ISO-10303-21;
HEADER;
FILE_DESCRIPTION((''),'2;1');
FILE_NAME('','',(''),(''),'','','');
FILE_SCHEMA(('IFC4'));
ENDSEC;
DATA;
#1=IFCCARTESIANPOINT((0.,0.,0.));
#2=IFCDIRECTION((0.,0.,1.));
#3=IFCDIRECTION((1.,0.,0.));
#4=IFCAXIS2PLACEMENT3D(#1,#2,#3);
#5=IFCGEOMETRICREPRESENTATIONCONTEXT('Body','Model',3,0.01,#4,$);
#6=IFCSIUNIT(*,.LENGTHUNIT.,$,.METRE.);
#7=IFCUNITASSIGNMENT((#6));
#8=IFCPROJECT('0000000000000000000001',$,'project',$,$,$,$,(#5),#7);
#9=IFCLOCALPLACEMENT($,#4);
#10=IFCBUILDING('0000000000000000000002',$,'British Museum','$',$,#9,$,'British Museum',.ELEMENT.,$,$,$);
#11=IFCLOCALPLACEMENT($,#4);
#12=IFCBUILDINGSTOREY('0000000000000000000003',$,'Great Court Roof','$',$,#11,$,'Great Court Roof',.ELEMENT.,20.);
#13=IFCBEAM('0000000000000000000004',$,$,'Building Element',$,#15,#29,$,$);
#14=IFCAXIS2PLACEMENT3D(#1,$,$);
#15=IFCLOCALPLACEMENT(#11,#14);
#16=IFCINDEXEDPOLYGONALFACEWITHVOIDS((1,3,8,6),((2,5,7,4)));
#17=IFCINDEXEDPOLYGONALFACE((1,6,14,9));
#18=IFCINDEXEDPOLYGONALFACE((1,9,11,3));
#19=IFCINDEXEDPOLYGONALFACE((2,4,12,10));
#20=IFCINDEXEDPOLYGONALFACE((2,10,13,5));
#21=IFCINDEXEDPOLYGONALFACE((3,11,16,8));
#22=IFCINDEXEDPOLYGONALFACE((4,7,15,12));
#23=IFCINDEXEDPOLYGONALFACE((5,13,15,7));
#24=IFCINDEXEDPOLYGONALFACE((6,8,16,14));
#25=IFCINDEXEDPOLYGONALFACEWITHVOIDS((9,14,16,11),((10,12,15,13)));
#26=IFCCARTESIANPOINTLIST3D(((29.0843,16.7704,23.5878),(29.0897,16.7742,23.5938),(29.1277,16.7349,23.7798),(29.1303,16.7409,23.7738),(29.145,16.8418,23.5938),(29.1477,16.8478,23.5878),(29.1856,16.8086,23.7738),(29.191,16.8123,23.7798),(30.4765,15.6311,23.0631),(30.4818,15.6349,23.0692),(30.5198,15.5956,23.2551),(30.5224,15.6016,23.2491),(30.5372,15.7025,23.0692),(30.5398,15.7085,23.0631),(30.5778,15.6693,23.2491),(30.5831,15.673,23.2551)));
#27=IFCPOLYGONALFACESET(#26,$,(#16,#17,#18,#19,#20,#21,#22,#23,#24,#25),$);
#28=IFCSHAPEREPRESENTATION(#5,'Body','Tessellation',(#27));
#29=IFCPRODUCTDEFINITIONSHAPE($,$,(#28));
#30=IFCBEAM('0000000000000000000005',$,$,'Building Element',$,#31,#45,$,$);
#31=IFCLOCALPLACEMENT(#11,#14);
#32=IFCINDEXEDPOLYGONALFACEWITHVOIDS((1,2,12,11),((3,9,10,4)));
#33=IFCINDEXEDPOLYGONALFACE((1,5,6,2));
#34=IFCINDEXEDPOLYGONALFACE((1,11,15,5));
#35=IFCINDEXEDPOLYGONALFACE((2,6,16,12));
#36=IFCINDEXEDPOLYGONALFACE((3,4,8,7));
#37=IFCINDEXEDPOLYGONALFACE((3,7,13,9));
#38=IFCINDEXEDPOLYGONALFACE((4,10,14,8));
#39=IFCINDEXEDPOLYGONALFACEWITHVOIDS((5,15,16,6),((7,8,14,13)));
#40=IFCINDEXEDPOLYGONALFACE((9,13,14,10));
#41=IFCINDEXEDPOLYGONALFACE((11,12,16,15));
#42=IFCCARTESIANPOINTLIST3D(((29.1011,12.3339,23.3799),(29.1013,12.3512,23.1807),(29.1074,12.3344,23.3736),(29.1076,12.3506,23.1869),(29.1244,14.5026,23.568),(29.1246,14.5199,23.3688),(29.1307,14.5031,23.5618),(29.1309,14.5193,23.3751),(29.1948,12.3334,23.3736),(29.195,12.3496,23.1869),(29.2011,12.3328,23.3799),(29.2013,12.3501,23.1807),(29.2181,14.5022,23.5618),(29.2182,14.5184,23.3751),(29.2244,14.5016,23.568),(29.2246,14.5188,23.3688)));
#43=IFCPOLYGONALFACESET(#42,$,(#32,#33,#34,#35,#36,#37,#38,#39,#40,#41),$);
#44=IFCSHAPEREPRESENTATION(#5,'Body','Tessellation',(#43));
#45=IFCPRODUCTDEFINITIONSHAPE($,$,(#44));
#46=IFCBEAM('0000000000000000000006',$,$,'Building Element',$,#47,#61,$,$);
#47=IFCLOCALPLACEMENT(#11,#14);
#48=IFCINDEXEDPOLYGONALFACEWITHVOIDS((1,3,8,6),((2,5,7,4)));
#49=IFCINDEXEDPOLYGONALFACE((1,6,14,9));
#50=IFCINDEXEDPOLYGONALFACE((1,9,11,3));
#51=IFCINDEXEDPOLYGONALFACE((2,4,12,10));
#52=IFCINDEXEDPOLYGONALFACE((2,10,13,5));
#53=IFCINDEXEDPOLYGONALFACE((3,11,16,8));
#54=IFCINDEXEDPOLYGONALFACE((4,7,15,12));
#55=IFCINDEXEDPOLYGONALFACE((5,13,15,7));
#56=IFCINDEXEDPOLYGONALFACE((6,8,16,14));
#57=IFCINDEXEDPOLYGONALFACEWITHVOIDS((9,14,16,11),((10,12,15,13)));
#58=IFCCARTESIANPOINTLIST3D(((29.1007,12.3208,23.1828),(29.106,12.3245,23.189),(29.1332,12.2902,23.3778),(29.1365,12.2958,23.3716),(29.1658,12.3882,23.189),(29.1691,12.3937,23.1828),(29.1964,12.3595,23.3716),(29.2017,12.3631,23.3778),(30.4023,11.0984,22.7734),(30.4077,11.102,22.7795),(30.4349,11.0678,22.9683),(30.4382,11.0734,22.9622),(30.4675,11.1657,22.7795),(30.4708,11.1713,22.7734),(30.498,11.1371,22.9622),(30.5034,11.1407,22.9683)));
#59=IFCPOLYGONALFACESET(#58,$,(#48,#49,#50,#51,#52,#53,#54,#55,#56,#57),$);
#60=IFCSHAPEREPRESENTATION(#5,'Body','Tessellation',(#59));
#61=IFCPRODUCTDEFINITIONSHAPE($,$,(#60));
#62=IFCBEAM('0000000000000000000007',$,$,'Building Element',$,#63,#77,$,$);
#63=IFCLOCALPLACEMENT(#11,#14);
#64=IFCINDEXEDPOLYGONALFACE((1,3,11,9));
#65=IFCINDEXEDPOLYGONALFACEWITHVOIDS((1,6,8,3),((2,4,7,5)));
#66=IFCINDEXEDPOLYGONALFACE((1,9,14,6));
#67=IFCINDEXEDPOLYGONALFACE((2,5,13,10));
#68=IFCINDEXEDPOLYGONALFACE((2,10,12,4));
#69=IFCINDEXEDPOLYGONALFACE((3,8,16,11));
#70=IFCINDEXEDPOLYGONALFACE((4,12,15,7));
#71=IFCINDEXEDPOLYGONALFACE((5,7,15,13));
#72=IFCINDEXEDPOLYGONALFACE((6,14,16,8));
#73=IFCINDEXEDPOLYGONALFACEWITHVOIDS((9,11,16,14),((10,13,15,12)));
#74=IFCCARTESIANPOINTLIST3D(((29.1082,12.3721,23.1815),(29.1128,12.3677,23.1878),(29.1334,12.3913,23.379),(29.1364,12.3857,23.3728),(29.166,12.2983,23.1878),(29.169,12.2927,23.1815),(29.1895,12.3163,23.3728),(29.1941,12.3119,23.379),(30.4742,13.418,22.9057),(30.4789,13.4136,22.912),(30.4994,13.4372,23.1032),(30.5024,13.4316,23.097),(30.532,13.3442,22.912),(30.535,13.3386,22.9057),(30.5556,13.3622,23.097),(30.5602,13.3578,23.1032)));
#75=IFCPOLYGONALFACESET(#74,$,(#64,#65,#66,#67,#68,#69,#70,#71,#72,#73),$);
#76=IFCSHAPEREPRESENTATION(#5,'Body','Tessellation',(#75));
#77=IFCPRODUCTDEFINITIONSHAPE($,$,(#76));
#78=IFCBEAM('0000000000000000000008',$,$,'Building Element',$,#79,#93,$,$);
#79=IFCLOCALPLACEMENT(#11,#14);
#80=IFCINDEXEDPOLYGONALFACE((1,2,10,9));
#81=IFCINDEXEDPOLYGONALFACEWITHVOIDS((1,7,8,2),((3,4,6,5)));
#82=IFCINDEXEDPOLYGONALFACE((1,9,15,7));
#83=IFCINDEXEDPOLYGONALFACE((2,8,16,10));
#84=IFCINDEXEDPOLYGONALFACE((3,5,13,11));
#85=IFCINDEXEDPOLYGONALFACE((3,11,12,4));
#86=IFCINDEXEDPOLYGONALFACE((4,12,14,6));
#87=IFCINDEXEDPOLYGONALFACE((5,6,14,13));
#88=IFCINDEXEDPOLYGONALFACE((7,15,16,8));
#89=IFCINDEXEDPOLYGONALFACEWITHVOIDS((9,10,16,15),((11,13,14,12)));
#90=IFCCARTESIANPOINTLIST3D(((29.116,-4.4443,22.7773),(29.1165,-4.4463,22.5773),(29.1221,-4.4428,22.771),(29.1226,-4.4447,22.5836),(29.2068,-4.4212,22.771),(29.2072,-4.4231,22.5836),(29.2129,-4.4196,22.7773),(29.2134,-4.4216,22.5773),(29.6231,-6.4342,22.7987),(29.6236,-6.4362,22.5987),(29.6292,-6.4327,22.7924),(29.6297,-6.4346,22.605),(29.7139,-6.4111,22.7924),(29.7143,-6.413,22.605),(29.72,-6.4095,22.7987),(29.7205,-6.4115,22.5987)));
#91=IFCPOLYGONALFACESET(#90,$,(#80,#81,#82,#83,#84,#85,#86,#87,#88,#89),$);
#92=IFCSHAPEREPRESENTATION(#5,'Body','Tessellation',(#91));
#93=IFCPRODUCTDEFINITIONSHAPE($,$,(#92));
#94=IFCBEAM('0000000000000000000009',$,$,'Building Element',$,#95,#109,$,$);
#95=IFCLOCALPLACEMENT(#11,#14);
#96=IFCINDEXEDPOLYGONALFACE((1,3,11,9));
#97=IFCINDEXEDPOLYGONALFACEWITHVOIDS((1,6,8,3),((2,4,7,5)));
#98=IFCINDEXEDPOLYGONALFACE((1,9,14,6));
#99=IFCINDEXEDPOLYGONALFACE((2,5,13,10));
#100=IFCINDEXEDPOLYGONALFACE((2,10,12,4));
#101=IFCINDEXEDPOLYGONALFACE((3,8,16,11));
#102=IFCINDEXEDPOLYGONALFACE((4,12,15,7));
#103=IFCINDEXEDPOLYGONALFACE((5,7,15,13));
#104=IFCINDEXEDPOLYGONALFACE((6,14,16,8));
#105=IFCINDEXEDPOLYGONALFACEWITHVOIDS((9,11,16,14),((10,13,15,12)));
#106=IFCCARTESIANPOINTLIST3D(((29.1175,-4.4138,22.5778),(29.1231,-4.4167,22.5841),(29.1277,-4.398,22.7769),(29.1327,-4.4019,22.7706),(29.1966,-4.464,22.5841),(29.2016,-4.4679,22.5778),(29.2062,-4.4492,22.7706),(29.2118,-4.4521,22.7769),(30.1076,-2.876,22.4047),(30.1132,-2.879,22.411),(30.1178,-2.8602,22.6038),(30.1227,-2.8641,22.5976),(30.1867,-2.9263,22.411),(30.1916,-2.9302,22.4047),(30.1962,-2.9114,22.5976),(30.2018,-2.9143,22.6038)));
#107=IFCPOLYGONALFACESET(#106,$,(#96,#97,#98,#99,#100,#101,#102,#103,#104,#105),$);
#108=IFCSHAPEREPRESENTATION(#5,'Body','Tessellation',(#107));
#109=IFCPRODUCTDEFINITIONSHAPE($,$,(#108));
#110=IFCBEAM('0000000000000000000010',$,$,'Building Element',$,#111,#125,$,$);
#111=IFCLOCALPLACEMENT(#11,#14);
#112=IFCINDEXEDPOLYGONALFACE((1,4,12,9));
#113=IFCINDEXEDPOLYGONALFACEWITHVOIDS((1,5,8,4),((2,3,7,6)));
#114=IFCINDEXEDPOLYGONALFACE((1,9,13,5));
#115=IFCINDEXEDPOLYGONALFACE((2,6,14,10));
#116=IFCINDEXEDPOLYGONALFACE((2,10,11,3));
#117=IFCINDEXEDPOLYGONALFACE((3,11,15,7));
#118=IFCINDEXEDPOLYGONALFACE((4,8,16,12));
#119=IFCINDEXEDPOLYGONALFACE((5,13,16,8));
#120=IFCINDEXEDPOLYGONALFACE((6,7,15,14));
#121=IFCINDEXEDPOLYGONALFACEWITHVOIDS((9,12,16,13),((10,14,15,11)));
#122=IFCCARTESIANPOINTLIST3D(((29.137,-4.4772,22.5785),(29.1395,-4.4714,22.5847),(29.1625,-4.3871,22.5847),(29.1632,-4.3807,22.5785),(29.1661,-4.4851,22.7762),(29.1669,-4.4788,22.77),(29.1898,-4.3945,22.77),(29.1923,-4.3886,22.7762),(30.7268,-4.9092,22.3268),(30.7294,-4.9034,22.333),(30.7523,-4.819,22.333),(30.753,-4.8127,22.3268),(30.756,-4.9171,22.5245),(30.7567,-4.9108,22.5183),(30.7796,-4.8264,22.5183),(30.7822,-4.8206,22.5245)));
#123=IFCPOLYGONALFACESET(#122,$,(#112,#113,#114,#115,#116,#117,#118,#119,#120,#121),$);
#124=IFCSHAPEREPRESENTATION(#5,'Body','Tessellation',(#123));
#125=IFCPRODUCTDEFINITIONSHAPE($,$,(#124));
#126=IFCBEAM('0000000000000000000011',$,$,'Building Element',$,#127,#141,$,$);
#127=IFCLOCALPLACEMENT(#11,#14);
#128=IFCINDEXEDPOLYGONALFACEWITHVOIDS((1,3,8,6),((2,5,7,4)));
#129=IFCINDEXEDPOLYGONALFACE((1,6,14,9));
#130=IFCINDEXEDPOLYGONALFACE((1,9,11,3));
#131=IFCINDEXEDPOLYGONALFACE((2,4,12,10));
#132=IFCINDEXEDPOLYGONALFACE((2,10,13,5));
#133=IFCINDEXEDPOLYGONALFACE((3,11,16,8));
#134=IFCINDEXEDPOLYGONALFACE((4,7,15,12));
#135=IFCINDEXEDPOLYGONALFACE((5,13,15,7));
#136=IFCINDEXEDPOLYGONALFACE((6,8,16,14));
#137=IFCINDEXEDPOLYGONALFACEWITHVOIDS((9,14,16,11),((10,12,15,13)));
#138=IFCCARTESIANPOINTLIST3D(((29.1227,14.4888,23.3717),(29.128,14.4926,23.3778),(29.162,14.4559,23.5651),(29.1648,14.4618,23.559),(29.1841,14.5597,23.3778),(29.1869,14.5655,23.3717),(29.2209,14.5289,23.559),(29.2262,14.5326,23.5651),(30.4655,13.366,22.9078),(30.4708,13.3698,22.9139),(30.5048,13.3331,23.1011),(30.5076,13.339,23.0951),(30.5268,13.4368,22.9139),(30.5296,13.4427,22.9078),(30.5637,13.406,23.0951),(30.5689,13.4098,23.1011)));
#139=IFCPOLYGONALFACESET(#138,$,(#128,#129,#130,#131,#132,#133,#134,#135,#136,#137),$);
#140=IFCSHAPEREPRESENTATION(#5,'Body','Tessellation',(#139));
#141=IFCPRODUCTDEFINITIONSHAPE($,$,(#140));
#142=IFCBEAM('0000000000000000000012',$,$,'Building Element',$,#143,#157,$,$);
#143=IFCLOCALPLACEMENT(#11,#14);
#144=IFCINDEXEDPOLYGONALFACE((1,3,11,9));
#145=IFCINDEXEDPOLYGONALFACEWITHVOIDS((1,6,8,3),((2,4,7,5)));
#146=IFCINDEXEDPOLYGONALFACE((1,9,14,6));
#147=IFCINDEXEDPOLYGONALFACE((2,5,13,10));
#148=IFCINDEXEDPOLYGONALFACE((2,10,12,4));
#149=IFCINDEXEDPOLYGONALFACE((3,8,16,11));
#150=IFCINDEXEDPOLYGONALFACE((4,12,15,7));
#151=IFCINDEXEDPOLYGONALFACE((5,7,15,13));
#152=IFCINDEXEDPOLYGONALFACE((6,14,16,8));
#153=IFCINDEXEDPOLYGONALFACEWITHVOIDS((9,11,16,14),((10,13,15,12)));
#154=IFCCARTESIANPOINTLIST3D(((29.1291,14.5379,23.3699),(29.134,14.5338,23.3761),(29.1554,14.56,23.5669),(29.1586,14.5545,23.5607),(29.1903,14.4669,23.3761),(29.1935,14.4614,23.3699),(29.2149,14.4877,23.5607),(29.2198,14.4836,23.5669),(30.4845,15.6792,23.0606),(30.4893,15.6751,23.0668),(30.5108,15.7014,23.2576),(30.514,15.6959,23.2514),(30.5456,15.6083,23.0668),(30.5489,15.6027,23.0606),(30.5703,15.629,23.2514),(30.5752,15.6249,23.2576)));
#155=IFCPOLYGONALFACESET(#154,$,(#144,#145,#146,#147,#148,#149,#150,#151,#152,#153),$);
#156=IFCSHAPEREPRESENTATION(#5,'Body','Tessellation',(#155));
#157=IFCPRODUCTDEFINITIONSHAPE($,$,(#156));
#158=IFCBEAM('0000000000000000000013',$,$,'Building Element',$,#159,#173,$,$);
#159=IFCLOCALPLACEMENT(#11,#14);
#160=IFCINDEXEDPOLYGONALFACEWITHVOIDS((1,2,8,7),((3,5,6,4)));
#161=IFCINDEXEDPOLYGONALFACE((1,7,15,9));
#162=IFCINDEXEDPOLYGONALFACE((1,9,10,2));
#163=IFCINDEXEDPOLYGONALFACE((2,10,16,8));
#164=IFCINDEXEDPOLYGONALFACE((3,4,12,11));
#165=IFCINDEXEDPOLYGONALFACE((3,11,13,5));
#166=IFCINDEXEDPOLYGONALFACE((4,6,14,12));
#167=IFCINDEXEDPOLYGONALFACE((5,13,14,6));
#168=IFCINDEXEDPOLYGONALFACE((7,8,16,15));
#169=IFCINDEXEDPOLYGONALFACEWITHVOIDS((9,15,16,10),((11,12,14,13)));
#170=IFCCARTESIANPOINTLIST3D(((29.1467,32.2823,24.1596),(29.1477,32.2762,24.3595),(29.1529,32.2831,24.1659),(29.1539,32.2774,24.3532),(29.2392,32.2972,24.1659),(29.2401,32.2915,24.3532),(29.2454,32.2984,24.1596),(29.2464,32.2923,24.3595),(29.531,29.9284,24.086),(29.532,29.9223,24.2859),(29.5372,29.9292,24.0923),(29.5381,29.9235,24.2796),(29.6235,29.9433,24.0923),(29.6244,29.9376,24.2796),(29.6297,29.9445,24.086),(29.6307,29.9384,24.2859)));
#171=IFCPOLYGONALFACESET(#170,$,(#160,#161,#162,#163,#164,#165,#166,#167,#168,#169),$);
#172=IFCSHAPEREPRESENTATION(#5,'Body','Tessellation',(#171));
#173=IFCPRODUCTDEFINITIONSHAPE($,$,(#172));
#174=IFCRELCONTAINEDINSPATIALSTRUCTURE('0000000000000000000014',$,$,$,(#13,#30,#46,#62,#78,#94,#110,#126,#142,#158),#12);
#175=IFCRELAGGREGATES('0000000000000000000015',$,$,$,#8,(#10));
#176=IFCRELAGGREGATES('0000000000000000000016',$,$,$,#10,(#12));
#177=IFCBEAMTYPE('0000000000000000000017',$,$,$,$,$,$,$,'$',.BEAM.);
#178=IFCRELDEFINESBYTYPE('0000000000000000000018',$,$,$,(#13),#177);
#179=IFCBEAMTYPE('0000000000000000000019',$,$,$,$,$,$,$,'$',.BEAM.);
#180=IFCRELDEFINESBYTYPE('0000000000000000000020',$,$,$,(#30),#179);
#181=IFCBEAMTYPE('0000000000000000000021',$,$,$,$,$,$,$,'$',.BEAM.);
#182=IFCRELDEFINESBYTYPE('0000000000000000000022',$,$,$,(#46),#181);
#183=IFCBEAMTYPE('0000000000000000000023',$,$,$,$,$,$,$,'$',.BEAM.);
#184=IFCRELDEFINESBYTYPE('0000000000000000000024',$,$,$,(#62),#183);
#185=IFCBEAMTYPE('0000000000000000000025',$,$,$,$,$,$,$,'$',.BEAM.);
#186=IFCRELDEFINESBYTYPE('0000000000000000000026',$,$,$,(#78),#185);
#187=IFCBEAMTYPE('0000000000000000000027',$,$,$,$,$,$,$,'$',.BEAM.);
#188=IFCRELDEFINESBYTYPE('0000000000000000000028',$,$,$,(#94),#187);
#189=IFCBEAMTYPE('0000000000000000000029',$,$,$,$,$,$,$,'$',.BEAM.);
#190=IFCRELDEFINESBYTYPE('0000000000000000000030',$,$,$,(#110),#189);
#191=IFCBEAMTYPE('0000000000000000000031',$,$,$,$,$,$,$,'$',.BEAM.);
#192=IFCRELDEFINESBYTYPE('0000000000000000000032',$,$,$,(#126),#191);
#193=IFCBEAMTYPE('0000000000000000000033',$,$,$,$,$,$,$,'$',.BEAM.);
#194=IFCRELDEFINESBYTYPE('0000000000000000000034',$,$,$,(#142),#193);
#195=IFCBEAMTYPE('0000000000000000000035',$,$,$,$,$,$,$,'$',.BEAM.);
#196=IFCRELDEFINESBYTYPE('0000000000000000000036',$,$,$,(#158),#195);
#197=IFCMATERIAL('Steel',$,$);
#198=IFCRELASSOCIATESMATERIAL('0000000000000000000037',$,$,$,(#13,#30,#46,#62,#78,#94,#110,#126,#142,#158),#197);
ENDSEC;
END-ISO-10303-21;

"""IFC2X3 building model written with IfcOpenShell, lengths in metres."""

from ifc_helpers import new_model, si_unit, frame, origin_with_axes, origin_2d, place, context, project, spatial, hollow_rectangle, extrude, material, type_object, element, save


model = new_model("IFC2X3")

# Units and contexts
model_context = context("Model", 3, precision=0.01, world=origin_with_axes(), identifier="Body")
ifc_project = project(units=[si_unit("LENGTHUNIT", "METRE")], contexts=[model_context])

# Building, storey
building_placement = place(None, origin_with_axes())
building = spatial("IfcBuilding", under=ifc_project, at=building_placement, Name="British Museum", Description="$", LongName="British Museum", CompositionType="ELEMENT")
storey_placement = place(None, origin_with_axes())
storey = spatial("IfcBuildingStorey", under=building, at=storey_placement, Name="Great Court Roof", Description="$", LongName="Great Court Roof", CompositionType="ELEMENT", Elevation=20.0)

# Beams
ifc_material = material(Name="Steel")
beam_type_1 = type_object("IfcBeamType", ElementType="$", PredefinedType="BEAM")
beam_1_placement = place(None, origin_with_axes())
element("IfcBeam", 1, at=beam_1_placement, inside=storey, type_object=beam_type_1, material=ifc_material, Description="Building Element", context=model_context, shape_type="SweptSolid", body=[
    extrude(hollow_rectangle(XDim=0.1, YDim=0.2, WallThickness=0.0063, InnerFilletRadius=-0.0063, OuterFilletRadius=0.0, at=origin_2d()), frame((29.1377, 16.7914, 23.6838), z_axis=(0.742926, -0.607998, -0.279999), x_axis=(0.633331, 0.773881, 0.0)), (0.0, 0.0, 1.0), 1.8739),
])
beam_type_2 = type_object("IfcBeamType", ElementType="$", PredefinedType="BEAM")
beam_2_placement = place(None, origin_with_axes())
element("IfcBeam", 2, at=beam_2_placement, inside=storey, type_object=beam_type_2, material=ifc_material, Description="Building Element", context=model_context, shape_type="SweptSolid", body=[
    extrude(hollow_rectangle(XDim=0.1, YDim=0.2, WallThickness=0.0063, InnerFilletRadius=-0.0063, OuterFilletRadius=0.0, at=origin_2d()), frame((29.1512, 12.342, 23.2803), z_axis=(0.010694, 0.996202, 0.086415), x_axis=(-0.999942, 0.010734, 0.0)), (0.0, 0.0, 1.0), 2.177),
])
beam_type_3 = type_object("IfcBeamType", ElementType="$", PredefinedType="BEAM")
beam_3_placement = place(None, origin_with_axes())
element("IfcBeam", 3, at=beam_3_placement, inside=storey, type_object=beam_type_3, material=ifc_material, Description="Building Element", context=model_context, shape_type="SweptSolid", body=[
    extrude(hollow_rectangle(XDim=0.1, YDim=0.2, WallThickness=0.0063, InnerFilletRadius=-0.0063, OuterFilletRadius=0.0, at=origin_2d()), frame((29.1512, 12.342, 23.2803), z_axis=(0.710504, -0.667259, -0.223495), x_axis=(0.684575, 0.728942, 0.0)), (0.0, 0.0, 1.0), 1.832),
])
beam_type_4 = type_object("IfcBeamType", ElementType="$", PredefinedType="BEAM")
beam_4_placement = place(None, origin_with_axes())
element("IfcBeam", 4, at=beam_4_placement, inside=storey, type_object=beam_type_4, material=ifc_material, Description="Building Element", context=model_context, shape_type="SweptSolid", body=[
    extrude(hollow_rectangle(XDim=0.1, YDim=0.2, WallThickness=0.0063, InnerFilletRadius=-0.0063, OuterFilletRadius=0.0, at=origin_2d()), frame((29.1512, 12.342, 23.2803), z_axis=(0.783987, 0.600257, -0.158288), x_axis=(-0.607921, 0.793997, 0.0)), (0.0, 0.0, 1.0), 1.7424),
])
beam_type_5 = type_object("IfcBeamType", ElementType="$", PredefinedType="BEAM")
beam_5_placement = place(None, origin_with_axes())
element("IfcBeam", 5, at=beam_5_placement, inside=storey, type_object=beam_type_5, material=ifc_material, Description="Building Element", context=model_context, shape_type="SweptSolid", body=[
    extrude(hollow_rectangle(XDim=0.1, YDim=0.2, WallThickness=0.0063, InnerFilletRadius=-0.0063, OuterFilletRadius=0.0, at=origin_2d()), frame((29.1647, -4.4329, 22.6773), z_axis=(0.246931, -0.968977, 0.010389), x_axis=(0.96903, 0.246945, 0.0)), (0.0, 0.0, 1.0), 2.0536),
])
beam_type_6 = type_object("IfcBeamType", ElementType="$", PredefinedType="BEAM")
beam_6_placement = place(None, origin_with_axes())
element("IfcBeam", 6, at=beam_6_placement, inside=storey, type_object=beam_type_6, material=ifc_material, Description="Building Element", context=model_context, shape_type="SweptSolid", body=[
    extrude(hollow_rectangle(XDim=0.1, YDim=0.2, WallThickness=0.0063, InnerFilletRadius=-0.0063, OuterFilletRadius=0.0, at=origin_2d()), frame((29.1647, -4.4329, 22.6773), z_axis=(0.538927, 0.837069, -0.094198), x_axis=(-0.840807, 0.541334, 0.0)), (0.0, 0.0, 1.0), 1.8371),
])
beam_type_7 = type_object("IfcBeamType", ElementType="$", PredefinedType="BEAM")
beam_7_placement = place(None, origin_with_axes())
element("IfcBeam", 7, at=beam_7_placement, inside=storey, type_object=beam_type_7, material=ifc_material, Description="Building Element", context=model_context, shape_type="SweptSolid", body=[
    extrude(hollow_rectangle(XDim=0.1, YDim=0.2, WallThickness=0.0063, InnerFilletRadius=-0.0063, OuterFilletRadius=0.0, at=origin_2d()), frame((29.1647, -4.4329, 22.6773), z_axis=(0.953947, -0.259182, -0.151032), x_axis=(0.26219, 0.965016, 0.0)), (0.0, 0.0, 1.0), 1.6666),
])
beam_type_8 = type_object("IfcBeamType", ElementType="$", PredefinedType="BEAM")
beam_8_placement = place(None, origin_with_axes())
element("IfcBeam", 8, at=beam_8_placement, inside=storey, type_object=beam_type_8, material=ifc_material, Description="Building Element", context=model_context, shape_type="SweptSolid", body=[
    extrude(hollow_rectangle(XDim=0.1, YDim=0.2, WallThickness=0.0063, InnerFilletRadius=-0.0063, OuterFilletRadius=0.0, at=origin_2d()), frame((29.1745, 14.5107, 23.4684), z_axis=(0.741526, -0.62008, -0.256202), x_axis=(0.641491, 0.76713, 0.0)), (0.0, 0.0, 1.0), 1.8108),
])
beam_type_9 = type_object("IfcBeamType", ElementType="$", PredefinedType="BEAM")
beam_9_placement = place(None, origin_with_axes())
element("IfcBeam", 9, at=beam_9_placement, inside=storey, type_object=beam_type_9, material=ifc_material, Description="Building Element", context=model_context, shape_type="SweptSolid", body=[
    extrude(hollow_rectangle(XDim=0.1, YDim=0.2, WallThickness=0.0063, InnerFilletRadius=-0.0063, OuterFilletRadius=0.0, at=origin_2d()), frame((29.1745, 14.5107, 23.4684), z_axis=(0.753522, 0.634537, -0.171954), x_axis=(-0.644131, 0.764915, 0.0)), (0.0, 0.0, 1.0), 1.7987),
])
beam_type_10 = type_object("IfcBeamType", ElementType="$", PredefinedType="BEAM")
beam_10_placement = place(None, origin_with_axes())
element("IfcBeam", 10, at=beam_10_placement, inside=storey, type_object=beam_type_10, material=ifc_material, Description="Building Element", context=model_context, shape_type="SweptSolid", body=[
    extrude(hollow_rectangle(XDim=0.1, YDim=0.2, WallThickness=0.0063, InnerFilletRadius=-0.0063, OuterFilletRadius=0.0, at=origin_2d()), frame((29.1965, 32.2873, 24.2595), z_axis=(0.161037, -0.986467, -0.030834), x_axis=(0.986936, 0.161113, 0.0)), (0.0, 0.0, 1.0), 2.3862),
])

save(model, "model.ifc")
